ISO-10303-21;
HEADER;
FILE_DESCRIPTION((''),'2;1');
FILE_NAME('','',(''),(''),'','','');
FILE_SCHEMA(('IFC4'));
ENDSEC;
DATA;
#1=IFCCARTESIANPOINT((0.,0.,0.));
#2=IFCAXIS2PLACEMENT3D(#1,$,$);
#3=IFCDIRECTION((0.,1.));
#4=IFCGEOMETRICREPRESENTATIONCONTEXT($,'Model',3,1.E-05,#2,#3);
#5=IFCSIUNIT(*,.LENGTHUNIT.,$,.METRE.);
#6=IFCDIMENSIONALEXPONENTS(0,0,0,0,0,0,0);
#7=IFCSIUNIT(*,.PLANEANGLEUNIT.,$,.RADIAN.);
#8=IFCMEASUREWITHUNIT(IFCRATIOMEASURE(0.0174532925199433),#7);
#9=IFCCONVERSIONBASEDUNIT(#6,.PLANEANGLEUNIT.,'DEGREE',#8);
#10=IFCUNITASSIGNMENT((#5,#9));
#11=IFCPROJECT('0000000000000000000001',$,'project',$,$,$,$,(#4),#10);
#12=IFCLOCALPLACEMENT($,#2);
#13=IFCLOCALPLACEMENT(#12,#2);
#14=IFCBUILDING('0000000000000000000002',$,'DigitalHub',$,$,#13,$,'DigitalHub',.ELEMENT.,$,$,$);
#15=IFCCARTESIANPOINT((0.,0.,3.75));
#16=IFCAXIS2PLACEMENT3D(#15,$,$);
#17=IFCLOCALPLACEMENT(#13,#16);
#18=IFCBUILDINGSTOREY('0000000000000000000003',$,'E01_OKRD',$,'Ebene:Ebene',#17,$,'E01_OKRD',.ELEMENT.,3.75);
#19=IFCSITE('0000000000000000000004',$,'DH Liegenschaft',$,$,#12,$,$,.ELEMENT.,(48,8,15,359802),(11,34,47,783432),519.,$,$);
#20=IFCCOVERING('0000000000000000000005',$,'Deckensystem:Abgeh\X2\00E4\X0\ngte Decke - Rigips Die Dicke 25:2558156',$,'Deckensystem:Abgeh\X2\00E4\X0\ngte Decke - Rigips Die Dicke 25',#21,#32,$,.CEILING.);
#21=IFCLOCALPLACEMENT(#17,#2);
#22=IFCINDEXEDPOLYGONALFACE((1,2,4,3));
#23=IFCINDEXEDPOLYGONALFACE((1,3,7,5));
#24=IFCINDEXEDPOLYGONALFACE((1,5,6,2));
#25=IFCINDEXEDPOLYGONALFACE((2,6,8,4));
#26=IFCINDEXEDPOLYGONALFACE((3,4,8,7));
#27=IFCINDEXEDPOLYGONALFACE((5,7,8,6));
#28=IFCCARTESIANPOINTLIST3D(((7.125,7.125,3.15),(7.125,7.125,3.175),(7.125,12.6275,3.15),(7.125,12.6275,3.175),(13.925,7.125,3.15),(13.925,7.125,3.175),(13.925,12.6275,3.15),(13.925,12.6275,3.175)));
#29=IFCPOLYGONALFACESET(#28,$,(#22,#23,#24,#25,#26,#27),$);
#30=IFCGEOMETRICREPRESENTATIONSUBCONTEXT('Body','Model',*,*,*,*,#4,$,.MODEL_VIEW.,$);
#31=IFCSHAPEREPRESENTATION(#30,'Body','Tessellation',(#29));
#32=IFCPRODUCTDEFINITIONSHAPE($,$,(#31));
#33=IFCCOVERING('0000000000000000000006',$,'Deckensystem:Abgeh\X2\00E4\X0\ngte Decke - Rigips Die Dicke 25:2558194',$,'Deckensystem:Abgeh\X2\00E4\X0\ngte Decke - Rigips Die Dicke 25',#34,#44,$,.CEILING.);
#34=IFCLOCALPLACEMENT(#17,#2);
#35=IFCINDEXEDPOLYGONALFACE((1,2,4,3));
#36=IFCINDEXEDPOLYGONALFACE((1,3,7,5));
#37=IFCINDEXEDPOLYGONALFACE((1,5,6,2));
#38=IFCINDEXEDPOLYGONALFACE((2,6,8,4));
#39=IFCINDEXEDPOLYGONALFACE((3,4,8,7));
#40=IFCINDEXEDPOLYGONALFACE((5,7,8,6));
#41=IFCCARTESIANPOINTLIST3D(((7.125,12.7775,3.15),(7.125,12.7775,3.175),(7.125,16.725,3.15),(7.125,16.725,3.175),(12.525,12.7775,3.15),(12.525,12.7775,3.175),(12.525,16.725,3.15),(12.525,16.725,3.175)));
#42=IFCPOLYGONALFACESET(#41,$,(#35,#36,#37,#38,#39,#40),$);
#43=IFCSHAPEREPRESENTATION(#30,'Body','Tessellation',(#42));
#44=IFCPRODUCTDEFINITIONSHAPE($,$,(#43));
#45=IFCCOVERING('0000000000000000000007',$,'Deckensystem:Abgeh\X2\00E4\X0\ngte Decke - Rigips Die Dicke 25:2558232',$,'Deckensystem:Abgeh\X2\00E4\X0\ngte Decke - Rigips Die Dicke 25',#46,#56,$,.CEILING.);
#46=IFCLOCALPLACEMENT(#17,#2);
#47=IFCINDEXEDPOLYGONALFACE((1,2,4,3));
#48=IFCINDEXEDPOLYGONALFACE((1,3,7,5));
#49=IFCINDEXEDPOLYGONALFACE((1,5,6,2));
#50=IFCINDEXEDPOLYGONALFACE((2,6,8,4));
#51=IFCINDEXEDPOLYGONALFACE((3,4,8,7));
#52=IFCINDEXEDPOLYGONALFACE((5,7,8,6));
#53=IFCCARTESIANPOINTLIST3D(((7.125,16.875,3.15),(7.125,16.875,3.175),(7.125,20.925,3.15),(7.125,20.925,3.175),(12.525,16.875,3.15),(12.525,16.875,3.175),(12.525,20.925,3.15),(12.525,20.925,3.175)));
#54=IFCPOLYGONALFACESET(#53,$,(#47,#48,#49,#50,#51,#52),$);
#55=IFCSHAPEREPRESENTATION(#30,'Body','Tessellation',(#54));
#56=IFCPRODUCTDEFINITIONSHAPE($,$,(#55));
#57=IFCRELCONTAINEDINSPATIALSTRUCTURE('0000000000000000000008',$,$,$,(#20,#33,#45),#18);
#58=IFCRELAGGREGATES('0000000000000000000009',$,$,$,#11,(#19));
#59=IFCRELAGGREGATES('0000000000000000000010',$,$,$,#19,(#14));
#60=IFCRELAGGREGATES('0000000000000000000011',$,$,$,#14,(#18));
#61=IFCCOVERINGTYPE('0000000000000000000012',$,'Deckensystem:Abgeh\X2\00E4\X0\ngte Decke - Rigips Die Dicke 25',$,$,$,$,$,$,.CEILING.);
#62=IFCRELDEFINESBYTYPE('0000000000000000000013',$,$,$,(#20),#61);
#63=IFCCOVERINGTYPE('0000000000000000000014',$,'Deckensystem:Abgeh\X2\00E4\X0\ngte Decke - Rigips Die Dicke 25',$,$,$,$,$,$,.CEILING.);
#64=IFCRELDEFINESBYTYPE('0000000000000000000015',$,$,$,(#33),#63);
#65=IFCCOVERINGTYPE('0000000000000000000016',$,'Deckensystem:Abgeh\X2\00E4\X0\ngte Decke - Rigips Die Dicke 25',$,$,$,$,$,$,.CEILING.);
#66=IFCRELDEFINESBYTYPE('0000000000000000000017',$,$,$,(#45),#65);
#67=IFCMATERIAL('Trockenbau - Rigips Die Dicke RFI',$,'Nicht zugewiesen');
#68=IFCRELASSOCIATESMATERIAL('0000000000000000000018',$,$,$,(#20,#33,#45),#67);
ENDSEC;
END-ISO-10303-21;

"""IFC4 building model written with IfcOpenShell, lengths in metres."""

from ifc_helpers import new_model, entity, si_unit, converted_unit, direction, frame, origin, place, context, subcontext, project, spatial, indexed_curve, outline, extrude, material, type_object, element, save


model = new_model("IFC4")

# Units and contexts
model_context = context("Model", 3, precision=1e-05, world=origin(), true_north=direction((0.0, 1.0)))
body_context = subcontext(model_context, "Body", "Model", "MODEL_VIEW")
ifc_project = project(units=[si_unit("LENGTHUNIT", "METRE"), converted_unit("PLANEANGLEUNIT", "DEGREE", entity("IfcRatioMeasure", 0.0174532925199433), si_unit("PLANEANGLEUNIT", "RADIAN"), dimensions=[0, 0, 0, 0, 0, 0, 0])], contexts=[model_context])

# Site, building, storey
site_placement = place(None, frame((0.0, 0.0, 0.0)))
site = spatial("IfcSite", under=ifc_project, at=site_placement, Name="DH Liegenschaft", CompositionType="ELEMENT", RefLatitude=(48, 8, 15, 359802), RefLongitude=(11, 34, 47, 783432), RefElevation=519.0)
building_placement = place(site_placement, origin())
building = spatial("IfcBuilding", under=site, at=building_placement, Name="DigitalHub", LongName="DigitalHub", CompositionType="ELEMENT")
storey_placement = place(building_placement, frame((0.0, 0.0, 3.75)))
storey = spatial("IfcBuildingStorey", under=building, at=storey_placement, Name="E01_OKRD", ObjectType="Ebene:Ebene", LongName="E01_OKRD", CompositionType="ELEMENT", Elevation=3.75)

# Coverings
ifc_material_1 = material(Name="Trockenbau - Rigips Die Dicke RFI", Category="Nicht zugewiesen")
covering_type_1 = type_object("IfcCoveringType", Name="Deckensystem:Abgehängte Decke - Rigips Die Dicke 25", PredefinedType="CEILING")
covering_1_placement = place(storey_placement, frame((7.125, 7.125, 3.15)))
element("IfcCovering", 1, at=covering_1_placement, inside=storey, type_object=covering_type_1, material=ifc_material_1, Name="Deckensystem:Abgehängte Decke - Rigips Die Dicke 25:2558156", ObjectType="Deckensystem:Abgehängte Decke - Rigips Die Dicke 25", PredefinedType="CEILING", context=body_context, shape_type="SweptSolid", body=[
    extrude(outline(indexed_curve([(-3.4, -2.7512), (3.4, -2.7512), (3.4, 2.7512), (-3.4, 2.7512), (-3.4, -2.7512)], self_intersect=False)), frame((3.4, 2.7512, 0.0), z_axis=(0.0, 0.0, 1.0), x_axis=(-1.0, 0.0, 0.0)), (0.0, 0.0, 1.0), 0.025),
])
covering_type_2 = type_object("IfcCoveringType", Name="Deckensystem:Abgehängte Decke - Rigips Die Dicke 25", PredefinedType="CEILING")
covering_2_placement = place(storey_placement, frame((7.125, 12.7775, 3.15)))
element("IfcCovering", 2, at=covering_2_placement, inside=storey, type_object=covering_type_2, material=ifc_material_1, Name="Deckensystem:Abgehängte Decke - Rigips Die Dicke 25:2558194", ObjectType="Deckensystem:Abgehängte Decke - Rigips Die Dicke 25", PredefinedType="CEILING", context=body_context, shape_type="SweptSolid", body=[
    extrude(outline(indexed_curve([(-2.7, -1.9738), (2.7, -1.9738), (2.7, 1.9738), (-2.7, 1.9738), (-2.7, -1.9738)], self_intersect=False)), frame((2.7, 1.9738, 0.0)), (0.0, 0.0, 1.0), 0.025),
])
covering_type_3 = type_object("IfcCoveringType", Name="Deckensystem:Abgehängte Decke - Rigips Die Dicke 25", PredefinedType="CEILING")
covering_3_placement = place(storey_placement, frame((7.125, 16.875, 3.15)))
element("IfcCovering", 3, at=covering_3_placement, inside=storey, type_object=covering_type_3, material=ifc_material_1, Name="Deckensystem:Abgehängte Decke - Rigips Die Dicke 25:2558232", ObjectType="Deckensystem:Abgehängte Decke - Rigips Die Dicke 25", PredefinedType="CEILING", context=body_context, shape_type="SweptSolid", body=[
    extrude(outline(indexed_curve([(-2.7, -2.025), (2.7, -2.025), (2.7, 2.025), (-2.7, 2.025), (-2.7, -2.025)], self_intersect=False)), frame((2.7, 2.025, 0.0), z_axis=(0.0, 0.0, 1.0), x_axis=(-1.0, 0.0, 0.0)), (0.0, 0.0, 1.0), 0.025),
])

save(model, "model.ifc")
